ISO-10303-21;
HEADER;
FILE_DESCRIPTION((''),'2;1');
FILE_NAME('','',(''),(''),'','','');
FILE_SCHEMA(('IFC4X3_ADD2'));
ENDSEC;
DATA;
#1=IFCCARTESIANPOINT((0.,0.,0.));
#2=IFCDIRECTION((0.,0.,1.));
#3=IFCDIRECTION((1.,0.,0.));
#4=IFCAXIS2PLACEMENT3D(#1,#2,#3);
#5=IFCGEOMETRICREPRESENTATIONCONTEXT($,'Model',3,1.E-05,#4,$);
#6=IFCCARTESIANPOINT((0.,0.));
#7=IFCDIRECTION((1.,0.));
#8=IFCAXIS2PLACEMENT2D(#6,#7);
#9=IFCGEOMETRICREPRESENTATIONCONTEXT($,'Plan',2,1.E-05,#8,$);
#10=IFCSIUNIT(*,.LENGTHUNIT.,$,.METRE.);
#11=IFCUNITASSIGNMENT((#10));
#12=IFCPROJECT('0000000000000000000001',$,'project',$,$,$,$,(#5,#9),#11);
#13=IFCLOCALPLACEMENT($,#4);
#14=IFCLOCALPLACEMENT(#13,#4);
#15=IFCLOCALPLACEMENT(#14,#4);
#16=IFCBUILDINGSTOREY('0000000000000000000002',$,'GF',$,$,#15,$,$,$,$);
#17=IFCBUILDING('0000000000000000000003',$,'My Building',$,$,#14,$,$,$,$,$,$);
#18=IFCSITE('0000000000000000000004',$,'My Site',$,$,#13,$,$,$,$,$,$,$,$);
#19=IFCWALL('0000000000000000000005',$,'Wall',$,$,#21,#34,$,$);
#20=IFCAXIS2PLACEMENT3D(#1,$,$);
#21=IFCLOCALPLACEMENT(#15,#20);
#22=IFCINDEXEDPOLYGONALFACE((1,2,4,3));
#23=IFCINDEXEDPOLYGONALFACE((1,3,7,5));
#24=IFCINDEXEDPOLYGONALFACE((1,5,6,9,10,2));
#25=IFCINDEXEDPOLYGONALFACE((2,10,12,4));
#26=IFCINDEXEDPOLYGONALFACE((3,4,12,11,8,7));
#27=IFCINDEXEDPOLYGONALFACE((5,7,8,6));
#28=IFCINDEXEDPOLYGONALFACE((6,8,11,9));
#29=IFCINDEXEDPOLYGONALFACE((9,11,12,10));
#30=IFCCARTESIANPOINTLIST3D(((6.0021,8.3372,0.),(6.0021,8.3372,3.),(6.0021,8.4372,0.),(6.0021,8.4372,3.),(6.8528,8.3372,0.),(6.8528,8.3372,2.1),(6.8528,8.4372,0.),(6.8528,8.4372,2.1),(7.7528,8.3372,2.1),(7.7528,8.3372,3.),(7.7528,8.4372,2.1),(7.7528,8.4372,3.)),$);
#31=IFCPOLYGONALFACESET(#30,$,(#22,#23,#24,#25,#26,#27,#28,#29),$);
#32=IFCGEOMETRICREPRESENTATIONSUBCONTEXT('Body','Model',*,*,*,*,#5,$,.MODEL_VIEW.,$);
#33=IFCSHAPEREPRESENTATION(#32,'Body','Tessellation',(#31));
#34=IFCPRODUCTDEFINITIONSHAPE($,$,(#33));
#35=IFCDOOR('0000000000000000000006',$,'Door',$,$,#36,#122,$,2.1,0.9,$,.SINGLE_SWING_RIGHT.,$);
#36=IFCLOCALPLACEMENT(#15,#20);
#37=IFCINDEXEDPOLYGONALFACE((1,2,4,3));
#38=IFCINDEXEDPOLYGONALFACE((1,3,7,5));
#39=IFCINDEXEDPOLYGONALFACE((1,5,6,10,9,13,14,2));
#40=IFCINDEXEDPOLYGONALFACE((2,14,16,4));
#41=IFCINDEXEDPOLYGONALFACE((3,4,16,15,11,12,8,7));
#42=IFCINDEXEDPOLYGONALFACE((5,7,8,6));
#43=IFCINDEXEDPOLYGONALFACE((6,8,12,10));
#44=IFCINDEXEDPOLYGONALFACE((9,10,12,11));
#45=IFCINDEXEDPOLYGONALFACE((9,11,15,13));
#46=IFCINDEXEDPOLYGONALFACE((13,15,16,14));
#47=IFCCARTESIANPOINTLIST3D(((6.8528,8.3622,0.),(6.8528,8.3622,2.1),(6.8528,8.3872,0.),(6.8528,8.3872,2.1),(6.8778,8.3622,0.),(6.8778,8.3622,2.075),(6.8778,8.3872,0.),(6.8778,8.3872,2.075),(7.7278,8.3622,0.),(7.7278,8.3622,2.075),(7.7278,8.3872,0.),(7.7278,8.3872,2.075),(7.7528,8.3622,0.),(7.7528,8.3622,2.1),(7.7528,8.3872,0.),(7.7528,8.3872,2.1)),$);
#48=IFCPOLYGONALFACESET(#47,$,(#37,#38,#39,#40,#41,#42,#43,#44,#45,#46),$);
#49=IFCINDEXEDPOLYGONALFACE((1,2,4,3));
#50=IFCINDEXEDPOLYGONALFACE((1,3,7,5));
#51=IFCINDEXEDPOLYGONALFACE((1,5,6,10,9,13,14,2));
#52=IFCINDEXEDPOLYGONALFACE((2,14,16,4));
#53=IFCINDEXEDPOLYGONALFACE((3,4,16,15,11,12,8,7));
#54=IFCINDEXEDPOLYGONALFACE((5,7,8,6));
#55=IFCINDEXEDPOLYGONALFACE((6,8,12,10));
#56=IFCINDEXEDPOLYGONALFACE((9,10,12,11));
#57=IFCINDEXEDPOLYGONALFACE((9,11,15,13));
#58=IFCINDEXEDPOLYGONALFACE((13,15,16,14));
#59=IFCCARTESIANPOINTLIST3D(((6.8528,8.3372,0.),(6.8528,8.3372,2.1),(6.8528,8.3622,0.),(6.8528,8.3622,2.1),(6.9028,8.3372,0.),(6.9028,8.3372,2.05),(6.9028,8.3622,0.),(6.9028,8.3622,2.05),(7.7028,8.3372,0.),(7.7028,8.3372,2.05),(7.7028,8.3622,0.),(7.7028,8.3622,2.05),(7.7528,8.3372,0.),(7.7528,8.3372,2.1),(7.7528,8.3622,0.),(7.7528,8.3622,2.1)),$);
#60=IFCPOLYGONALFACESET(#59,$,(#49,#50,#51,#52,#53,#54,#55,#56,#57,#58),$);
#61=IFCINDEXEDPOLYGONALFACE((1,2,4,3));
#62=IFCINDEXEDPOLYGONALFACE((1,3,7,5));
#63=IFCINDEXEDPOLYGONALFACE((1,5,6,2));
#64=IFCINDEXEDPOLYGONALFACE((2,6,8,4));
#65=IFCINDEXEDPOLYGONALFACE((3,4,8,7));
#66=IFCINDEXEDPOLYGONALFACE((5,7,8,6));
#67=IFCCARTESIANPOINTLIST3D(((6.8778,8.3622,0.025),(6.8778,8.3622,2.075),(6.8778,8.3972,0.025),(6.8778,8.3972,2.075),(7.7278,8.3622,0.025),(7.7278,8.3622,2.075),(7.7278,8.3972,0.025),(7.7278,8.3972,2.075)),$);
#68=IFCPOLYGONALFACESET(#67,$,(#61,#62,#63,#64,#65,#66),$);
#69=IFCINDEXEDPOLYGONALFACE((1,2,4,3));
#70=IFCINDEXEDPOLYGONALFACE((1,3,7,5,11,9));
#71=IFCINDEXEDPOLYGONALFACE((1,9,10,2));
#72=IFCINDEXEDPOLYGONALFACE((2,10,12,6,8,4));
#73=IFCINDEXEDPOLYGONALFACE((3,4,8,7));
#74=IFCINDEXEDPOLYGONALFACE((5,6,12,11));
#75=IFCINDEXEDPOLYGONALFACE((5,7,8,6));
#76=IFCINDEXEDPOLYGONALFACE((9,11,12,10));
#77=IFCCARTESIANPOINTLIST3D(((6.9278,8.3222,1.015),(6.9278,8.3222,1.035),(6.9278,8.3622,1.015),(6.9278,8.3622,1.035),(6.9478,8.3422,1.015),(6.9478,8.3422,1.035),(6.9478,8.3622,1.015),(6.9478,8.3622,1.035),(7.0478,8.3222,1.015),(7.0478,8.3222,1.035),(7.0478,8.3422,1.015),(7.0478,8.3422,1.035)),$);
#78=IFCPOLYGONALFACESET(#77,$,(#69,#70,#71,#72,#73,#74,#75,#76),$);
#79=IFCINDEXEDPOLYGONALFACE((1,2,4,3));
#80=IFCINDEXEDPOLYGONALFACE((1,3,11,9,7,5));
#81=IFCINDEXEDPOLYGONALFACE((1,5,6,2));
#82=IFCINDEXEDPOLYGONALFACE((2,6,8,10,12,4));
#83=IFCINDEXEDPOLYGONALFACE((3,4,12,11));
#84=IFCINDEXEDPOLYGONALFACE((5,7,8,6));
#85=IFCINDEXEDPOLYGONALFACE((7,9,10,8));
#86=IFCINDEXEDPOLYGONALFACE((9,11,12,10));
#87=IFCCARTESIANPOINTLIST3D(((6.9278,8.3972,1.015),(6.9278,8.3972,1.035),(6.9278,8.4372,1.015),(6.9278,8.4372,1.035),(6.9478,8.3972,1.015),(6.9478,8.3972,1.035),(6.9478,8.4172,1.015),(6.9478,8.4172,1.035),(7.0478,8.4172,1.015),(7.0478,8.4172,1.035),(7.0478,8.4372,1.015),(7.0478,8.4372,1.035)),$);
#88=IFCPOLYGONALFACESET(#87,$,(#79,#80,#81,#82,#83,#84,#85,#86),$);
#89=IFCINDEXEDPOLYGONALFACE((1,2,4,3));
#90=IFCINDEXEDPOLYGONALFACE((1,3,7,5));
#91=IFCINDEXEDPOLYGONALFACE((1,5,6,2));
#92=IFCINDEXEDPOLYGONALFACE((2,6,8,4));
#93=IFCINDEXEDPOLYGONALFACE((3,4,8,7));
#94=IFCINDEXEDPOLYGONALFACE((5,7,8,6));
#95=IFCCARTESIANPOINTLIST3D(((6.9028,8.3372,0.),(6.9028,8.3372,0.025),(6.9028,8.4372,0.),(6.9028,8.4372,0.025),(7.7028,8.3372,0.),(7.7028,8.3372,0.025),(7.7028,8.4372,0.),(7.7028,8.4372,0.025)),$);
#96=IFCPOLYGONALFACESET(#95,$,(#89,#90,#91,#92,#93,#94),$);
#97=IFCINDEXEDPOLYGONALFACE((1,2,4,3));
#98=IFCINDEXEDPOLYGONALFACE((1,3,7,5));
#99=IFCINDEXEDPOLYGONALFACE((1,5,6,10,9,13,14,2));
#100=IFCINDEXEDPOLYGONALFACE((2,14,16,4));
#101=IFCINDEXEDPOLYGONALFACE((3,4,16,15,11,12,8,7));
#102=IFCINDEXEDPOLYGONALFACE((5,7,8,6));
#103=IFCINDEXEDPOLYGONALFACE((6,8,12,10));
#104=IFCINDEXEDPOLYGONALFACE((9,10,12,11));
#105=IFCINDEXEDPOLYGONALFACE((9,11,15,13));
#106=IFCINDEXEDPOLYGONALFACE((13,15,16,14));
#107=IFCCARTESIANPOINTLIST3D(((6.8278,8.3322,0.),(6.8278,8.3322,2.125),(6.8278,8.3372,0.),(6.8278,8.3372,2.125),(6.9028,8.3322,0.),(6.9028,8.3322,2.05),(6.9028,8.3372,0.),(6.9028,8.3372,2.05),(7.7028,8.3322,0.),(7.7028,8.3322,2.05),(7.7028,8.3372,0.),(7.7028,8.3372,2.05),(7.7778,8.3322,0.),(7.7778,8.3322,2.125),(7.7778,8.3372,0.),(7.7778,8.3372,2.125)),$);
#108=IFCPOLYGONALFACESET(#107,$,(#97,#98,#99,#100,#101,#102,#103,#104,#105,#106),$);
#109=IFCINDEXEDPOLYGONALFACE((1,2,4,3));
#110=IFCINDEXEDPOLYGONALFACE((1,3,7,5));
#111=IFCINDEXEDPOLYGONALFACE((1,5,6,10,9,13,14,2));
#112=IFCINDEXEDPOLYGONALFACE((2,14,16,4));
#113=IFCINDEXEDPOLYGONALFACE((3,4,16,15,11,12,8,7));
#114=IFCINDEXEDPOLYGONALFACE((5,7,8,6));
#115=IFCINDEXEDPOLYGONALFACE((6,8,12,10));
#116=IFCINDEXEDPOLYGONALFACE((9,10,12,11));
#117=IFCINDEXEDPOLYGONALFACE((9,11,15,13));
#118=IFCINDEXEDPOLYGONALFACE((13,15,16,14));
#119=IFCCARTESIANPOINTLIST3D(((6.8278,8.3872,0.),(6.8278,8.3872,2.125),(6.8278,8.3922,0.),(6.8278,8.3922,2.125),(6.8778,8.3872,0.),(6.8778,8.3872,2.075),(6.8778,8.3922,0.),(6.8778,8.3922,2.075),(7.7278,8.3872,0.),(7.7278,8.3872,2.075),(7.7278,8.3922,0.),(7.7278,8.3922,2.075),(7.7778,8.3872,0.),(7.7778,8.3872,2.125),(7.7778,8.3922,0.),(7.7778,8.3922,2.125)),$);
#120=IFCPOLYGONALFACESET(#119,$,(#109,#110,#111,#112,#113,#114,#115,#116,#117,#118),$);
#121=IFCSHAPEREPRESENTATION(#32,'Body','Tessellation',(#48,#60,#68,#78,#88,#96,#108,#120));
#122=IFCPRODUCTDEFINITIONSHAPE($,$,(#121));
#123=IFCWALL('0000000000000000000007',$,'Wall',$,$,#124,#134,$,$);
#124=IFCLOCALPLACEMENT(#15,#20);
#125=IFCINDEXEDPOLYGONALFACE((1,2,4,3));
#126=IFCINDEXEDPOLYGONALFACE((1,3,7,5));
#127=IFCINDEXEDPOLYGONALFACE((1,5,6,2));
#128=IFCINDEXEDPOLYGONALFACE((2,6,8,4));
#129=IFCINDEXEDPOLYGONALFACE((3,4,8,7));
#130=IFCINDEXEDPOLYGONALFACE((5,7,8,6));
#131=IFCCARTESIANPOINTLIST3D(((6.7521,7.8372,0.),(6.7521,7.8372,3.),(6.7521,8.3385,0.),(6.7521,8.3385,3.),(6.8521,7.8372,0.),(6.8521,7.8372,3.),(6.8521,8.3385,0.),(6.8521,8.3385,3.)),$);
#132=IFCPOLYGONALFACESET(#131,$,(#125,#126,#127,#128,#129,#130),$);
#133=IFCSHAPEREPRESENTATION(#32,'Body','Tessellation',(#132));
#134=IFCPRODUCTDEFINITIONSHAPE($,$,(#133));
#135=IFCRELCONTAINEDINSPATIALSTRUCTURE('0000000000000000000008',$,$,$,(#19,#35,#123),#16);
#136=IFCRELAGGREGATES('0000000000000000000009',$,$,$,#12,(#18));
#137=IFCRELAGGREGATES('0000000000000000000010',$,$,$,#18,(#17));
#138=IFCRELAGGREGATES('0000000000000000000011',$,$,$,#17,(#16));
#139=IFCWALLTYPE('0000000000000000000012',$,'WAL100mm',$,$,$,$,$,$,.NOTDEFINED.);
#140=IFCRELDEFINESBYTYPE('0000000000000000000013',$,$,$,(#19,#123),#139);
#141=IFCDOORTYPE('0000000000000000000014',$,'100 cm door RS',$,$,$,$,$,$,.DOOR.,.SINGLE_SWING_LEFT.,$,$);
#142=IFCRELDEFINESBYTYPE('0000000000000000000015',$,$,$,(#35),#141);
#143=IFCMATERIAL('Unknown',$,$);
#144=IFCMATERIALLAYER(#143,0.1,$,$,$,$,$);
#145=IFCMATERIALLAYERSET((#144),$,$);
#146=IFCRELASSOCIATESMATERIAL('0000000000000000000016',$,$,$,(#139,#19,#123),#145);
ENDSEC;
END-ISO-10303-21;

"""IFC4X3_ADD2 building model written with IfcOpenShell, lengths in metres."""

from ifc_helpers import new_model, entity, si_unit, frame, origin_with_axes, origin_2d_with_axis, place, context, subcontext, project, spatial, line, indexed_curve, outline, extrude, shape, source, transform, mapped, material, layer, layer_set, layer_usage, type_object, type_shapes, element, fill, save


model = new_model("IFC4X3_ADD2")

# Units and contexts
model_context = context("Model", 3, precision=1e-05, world=origin_with_axes())
plan_context = context("Plan", 2, precision=1e-05, world=origin_2d_with_axis())
body_context_1 = subcontext(model_context, "Body", "Model", "MODEL_VIEW")
body_context_2 = subcontext(plan_context, "Body", "Plan", "PLAN_VIEW")
ifc_project = project(units=[si_unit("LENGTHUNIT", "METRE")], contexts=[model_context, plan_context])

# Site, building, storey
site_placement = place(None, origin_with_axes())
site = spatial("IfcSite", under=ifc_project, at=site_placement, Name="My Site")
building_placement = place(site_placement, origin_with_axes())
building = spatial("IfcBuilding", under=site, at=building_placement, Name="My Building")
storey_placement = place(building_placement, origin_with_axes())
storey = spatial("IfcBuildingStorey", under=building, at=storey_placement, Name="GF")

# Wall, opening, door
ifc_material_1 = material(Name="Unknown")
ifc_layer_1 = layer(ifc_material_1, 0.1)
ifc_layer_set_1 = layer_set([ifc_layer_1])
ifc_layer_usage_1 = layer_usage(ifc_layer_set_1, "AXIS2", "POSITIVE", 0.0)
wall_type_1 = type_object("IfcWallType", Name="WAL100mm", PredefinedType="NOTDEFINED", material=ifc_layer_set_1)
wall_1_placement = place(storey_placement, frame((6.0021, 8.3372, 0.0), z_axis=(0.0, 0.0, 1.0), x_axis=(1.0, 0.0, 0.0)))
wall_1 = element("IfcWall", 1, at=wall_1_placement, inside=storey, type_object=wall_type_1, material=ifc_layer_usage_1, Name="Wall", context=body_context_1, shape_type="SweptSolid", body=[
    extrude(outline(indexed_curve([(0.0, 0.0), (0.0, 0.1), (1.7507, 0.1), (1.7507, 0.0)], segments=[line(1, 2, 3, 4, 1)])), origin_with_axes(), (0.0, 0.0, 1.0), 3.0),
])
shared_shape_1 = source(origin_with_axes(), body_context_1, "Body", "SweptSolid", [
    extrude(outline(indexed_curve([(0.0, 0.0), (0.9, 0.0), (0.9, 2.1), (0.0, 2.1)], segments=[line(1, 2, 3, 4, 1)])), frame((0.0, -0.6, 0.0), z_axis=(0.0, -1.0, 0.0), x_axis=(1.0, 0.0, 0.0)), (0.0, 0.0, -1.0), 1.2),
])
opening_1_placement = place(wall_1_placement, frame((0.8507, 0.0, 0.0), z_axis=(0.0, 0.0, 1.0), x_axis=(1.0, -0.000003, 0.0)))
opening_1 = element("IfcOpeningElement", 2, at=opening_1_placement, cuts=wall_1, PredefinedType="OPENING", context=body_context_1, shape_type="MappedRepresentation", body=[
    mapped(shared_shape_1, transform((0.0, 0.0, 0.0), x_axis=(1.0, 0.0, 0.0), y_axis=(0.0, 1.0, 0.0), z_axis=(0.0, 0.0, 1.0), scale=1.0)),
])
door_type_1 = type_object("IfcDoorType", Name="100 cm door RS", OperationType="SINGLE_SWING_LEFT", PredefinedType="DOOR")
shared_shape_2 = source(origin_with_axes(), body_context_1, "Body", "SweptSolid", [
    extrude(outline(indexed_curve([(0.0, 0.0), (0.0, 2.1), (0.9, 2.1), (0.9, 0.0), (0.875, 0.0), (0.875, 2.075), (0.025, 2.075), (0.025, 0.0)], segments=[line(1, 2, 3, 4, 5, 6, 7, 8, 1)])), frame((0.0, 0.025, 0.0), z_axis=(0.0, -1.0, 0.0), x_axis=(1.0, 0.0, 0.0)), (0.0, 0.0, -1.0), 0.025),
    extrude(outline(indexed_curve([(0.0, 0.0), (0.0, 2.1), (0.9, 2.1), (0.9, 0.0), (0.85, 0.0), (0.85, 2.05), (0.05, 2.05), (0.05, 0.0)], segments=[line(1, 2, 3, 4, 5, 6, 7, 8, 1)])), frame((0.0, 0.0, 0.0), z_axis=(0.0, -1.0, 0.0), x_axis=(1.0, 0.0, 0.0)), (0.0, 0.0, -1.0), 0.025),
    extrude(outline(indexed_curve([(0.0, 0.0), (0.85, 0.0), (0.85, 0.035), (0.0, 0.035)], segments=[line(1, 2, 3, 4, 1)])), frame((0.025, 0.025, 0.025), z_axis=(0.0, 0.0, 1.0), x_axis=(1.0, 0.0, 0.0)), (0.0, 0.0, 1.0), 2.05),
    extrude(outline(indexed_curve([(0.0, 0.0), (0.0, -0.04), (0.12, -0.04), (0.12, -0.02), (0.02, -0.02), (0.02, 0.0)], segments=[line(1, 2, 3, 4, 5, 6, 1)])), frame((0.075, 0.025, 1.015), z_axis=(0.0, 0.0, 1.0), x_axis=(1.0, 0.0, 0.0)), (0.0, 0.0, 1.0), 0.02),
    extrude(outline(indexed_curve([(0.0, 0.0), (0.0, 0.04), (0.12, 0.04), (0.12, 0.02), (0.02, 0.02), (0.02, 0.0)], segments=[line(1, 2, 3, 4, 5, 6, 1)])), frame((0.075, 0.06, 1.015), z_axis=(0.0, 0.0, 1.0), x_axis=(1.0, 0.0, 0.0)), (0.0, 0.0, 1.0), 0.02),
    extrude(outline(indexed_curve([(0.0, 0.0), (0.8, 0.0), (0.8, 0.1), (0.0, 0.1)], segments=[line(1, 2, 3, 4, 1)])), frame((0.05, 0.0, 0.0), z_axis=(0.0, 0.0, 1.0), x_axis=(1.0, 0.0, 0.0)), (0.0, 0.0, 1.0), 0.025),
    extrude(outline(indexed_curve([(0.0, 0.0), (0.0, 2.125), (0.95, 2.125), (0.95, 0.0), (0.875, 0.0), (0.875, 2.05), (0.075, 2.05), (0.075, 0.0)], segments=[line(1, 2, 3, 4, 5, 6, 7, 8, 1)])), frame((-0.025, -0.005, 0.0), z_axis=(0.0, -1.0, 0.0), x_axis=(1.0, 0.0, 0.0)), (0.0, 0.0, -1.0), 0.005),
    extrude(outline(indexed_curve([(0.0, 0.0), (0.0, 2.125), (0.95, 2.125), (0.95, 0.0), (0.9, 0.0), (0.9, 2.075), (0.05, 2.075), (0.05, 0.0)], segments=[line(1, 2, 3, 4, 5, 6, 7, 8, 1)])), frame((-0.025, 0.05, 0.0), z_axis=(0.0, -1.0, 0.0), x_axis=(1.0, 0.0, 0.0)), (0.0, 0.0, -1.0), 0.005),
])
shared_shape_3 = source(origin_with_axes(), body_context_2, "Body", "Curve2D", [
    entity("IfcIndexedPolyCurve", entity("IfcCartesianPointList2D", [[0.0, 0.0], [0.0, 0.05], [0.025, 0.05], [0.025, 0.025], [0.05, 0.025], [0.05, 0.0]]), [entity("IfcLineIndex", [1, 2, 3, 4, 5, 6, 1])]),
    entity("IfcIndexedPolyCurve", entity("IfcCartesianPointList2D", [[0.9, 0.0], [0.9, 0.05], [0.875, 0.05], [0.875, 0.025], [0.85, 0.025], [0.85, 0.0]]), [entity("IfcLineIndex", [1, 2, 3, 4, 5, 6, 1])]),
    entity("IfcTrimmedCurve", entity("IfcEllipse", entity("IfcAxis2Placement2D", entity("IfcCartesianPoint", [0.84, 0.05]), entity("IfcDirection", [1.0, 0.0])), 0.815, 0.85), [entity("IfcCartesianPoint", [0.84, 0.9])], [entity("IfcCartesianPoint", [0.025, 0.05])], True, "CARTESIAN"),
    entity("IfcIndexedPolyCurve", entity("IfcCartesianPointList2D", [[0.875, 0.05], [0.84, 0.05], [0.84, 0.9], [0.875, 0.9]]), [entity("IfcLineIndex", [1, 2, 3, 4, 1])]),
])
type_shapes(door_type_1, [shared_shape_2, shared_shape_3])
door_1_placement = place(opening_1_placement, frame((0.0, 0.0, 0.0), z_axis=(0.0, 0.0, 1.0), x_axis=(1.0, 0.0, 0.0)))
door_1 = element("IfcDoor", 3, at=door_1_placement, inside=storey, type_object=door_type_1, Name="Door", OperationType="SINGLE_SWING_RIGHT", OverallHeight=2.1, OverallWidth=0.9, shapes=[
    shape(body_context_1, "Body", "MappedRepresentation", [mapped(shared_shape_2, transform((0.0, 0.0, 0.0), x_axis=(1.0, 0.0, 0.0), y_axis=(0.0, 1.0, 0.0), z_axis=(0.0, 0.0, 1.0), scale=1.0))]),
    shape(body_context_2, "Body", "MappedRepresentation", [mapped(shared_shape_3, transform((0.0, 0.0, 0.0), x_axis=(1.0, 0.0, 0.0), y_axis=(0.0, 1.0, 0.0), z_axis=(0.0, 0.0, 1.0), scale=1.0))]),
])
fill(opening_1, door_1)

# Wall
ifc_layer_usage_2 = layer_usage(ifc_layer_set_1, "AXIS2", "POSITIVE", 0.0)
wall_2_placement = place(storey_placement, frame((6.7521, 8.3385, 0.0), z_axis=(0.0, 0.0, 1.0), x_axis=(0.0, -1.0, 0.0)))
element("IfcWall", 4, at=wall_2_placement, inside=storey, type_object=wall_type_1, material=ifc_layer_usage_2, Name="Wall", context=body_context_1, shape_type="SweptSolid", body=[
    extrude(outline(indexed_curve([(0.0, 0.0), (0.0, 0.1), (0.5014, 0.1), (0.5014, 0.0)], segments=[line(1, 2, 3, 4, 1)])), origin_with_axes(), (0.0, 0.0, 1.0), 3.0),
])

save(model, "model.ifc")
